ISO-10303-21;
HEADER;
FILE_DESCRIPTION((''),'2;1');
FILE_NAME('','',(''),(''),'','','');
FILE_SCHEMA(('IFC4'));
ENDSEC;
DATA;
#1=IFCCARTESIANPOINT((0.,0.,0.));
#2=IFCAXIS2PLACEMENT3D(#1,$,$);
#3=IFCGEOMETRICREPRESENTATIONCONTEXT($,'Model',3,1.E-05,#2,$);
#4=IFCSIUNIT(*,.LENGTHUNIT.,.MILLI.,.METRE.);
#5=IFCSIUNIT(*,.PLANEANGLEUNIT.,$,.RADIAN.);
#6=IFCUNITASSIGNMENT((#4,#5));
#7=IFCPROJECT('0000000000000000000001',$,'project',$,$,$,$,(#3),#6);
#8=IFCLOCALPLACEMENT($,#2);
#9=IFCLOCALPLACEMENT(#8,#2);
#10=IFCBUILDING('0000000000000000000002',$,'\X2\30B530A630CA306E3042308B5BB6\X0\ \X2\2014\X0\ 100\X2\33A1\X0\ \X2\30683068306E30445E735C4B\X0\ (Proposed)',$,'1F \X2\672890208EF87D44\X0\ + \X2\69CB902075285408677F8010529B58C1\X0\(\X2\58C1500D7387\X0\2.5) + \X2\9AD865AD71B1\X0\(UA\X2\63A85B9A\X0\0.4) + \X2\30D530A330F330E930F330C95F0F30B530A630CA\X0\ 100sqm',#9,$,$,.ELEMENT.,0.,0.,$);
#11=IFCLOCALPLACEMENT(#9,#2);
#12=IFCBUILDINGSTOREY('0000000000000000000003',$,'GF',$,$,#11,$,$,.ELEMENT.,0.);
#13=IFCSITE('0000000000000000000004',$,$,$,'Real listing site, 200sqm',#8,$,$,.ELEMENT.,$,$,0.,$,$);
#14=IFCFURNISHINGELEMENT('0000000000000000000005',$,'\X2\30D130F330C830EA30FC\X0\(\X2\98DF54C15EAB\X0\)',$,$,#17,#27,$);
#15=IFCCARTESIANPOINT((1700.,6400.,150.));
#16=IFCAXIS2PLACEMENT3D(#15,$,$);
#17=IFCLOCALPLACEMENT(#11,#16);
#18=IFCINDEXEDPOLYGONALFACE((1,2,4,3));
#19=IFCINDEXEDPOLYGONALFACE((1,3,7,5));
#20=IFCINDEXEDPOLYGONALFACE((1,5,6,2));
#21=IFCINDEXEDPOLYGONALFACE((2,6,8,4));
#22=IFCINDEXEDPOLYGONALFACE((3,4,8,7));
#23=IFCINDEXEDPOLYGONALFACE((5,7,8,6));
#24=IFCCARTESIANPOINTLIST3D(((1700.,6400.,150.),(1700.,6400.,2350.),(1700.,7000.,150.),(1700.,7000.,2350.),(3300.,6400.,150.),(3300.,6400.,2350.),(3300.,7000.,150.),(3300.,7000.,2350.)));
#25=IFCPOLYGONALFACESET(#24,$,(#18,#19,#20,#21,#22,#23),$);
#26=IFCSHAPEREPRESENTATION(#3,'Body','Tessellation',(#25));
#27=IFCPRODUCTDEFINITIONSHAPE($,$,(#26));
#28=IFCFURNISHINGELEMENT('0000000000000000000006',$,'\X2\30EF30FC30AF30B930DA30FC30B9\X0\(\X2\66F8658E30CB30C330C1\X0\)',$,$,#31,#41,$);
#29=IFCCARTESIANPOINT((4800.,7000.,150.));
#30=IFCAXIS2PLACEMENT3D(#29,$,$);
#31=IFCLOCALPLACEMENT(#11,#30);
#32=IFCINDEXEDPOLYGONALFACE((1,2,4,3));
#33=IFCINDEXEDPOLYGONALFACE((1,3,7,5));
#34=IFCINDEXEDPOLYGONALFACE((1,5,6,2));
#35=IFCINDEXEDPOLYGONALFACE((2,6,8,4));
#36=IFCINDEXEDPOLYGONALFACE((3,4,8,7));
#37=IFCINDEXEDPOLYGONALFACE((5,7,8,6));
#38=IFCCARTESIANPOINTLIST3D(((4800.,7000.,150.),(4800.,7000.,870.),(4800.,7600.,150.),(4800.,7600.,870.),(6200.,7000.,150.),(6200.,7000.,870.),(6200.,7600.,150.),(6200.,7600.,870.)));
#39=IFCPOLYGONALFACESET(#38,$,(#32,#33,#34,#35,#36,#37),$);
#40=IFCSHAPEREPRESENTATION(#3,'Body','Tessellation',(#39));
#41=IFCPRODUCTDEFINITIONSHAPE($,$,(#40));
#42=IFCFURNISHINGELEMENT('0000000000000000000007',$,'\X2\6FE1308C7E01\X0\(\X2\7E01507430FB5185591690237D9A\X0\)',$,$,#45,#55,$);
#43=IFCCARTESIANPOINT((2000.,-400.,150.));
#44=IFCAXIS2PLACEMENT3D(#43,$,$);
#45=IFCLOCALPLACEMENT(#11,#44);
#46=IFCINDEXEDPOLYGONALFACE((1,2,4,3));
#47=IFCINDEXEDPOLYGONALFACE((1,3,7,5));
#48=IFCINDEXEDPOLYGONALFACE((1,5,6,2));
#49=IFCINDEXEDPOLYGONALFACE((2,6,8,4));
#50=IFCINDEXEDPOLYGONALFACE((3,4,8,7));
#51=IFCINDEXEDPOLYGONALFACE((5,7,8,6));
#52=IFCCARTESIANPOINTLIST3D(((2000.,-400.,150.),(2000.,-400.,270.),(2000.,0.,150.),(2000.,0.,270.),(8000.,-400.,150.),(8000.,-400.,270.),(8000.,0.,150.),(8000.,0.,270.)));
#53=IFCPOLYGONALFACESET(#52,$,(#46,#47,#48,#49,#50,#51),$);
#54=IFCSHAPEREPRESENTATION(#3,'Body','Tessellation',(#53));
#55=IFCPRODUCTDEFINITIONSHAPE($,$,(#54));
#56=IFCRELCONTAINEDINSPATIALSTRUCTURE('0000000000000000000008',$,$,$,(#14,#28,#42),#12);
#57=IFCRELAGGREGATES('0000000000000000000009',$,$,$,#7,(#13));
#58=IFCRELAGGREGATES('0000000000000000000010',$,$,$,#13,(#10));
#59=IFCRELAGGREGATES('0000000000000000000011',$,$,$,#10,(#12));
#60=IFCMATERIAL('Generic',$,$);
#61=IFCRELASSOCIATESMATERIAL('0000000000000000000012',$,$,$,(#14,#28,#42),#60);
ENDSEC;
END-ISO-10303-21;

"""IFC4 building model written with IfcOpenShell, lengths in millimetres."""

from ifc_helpers import new_model, si_unit, frame, frame_2d, origin, place, context, project, spatial, rectangle, extrude, material, element, save


model = new_model("IFC4")

# Units and contexts
model_context = context("Model", 3, precision=1e-05, world=origin())
ifc_project = project(units=[si_unit("LENGTHUNIT", "METRE", prefix="MILLI"), si_unit("PLANEANGLEUNIT", "RADIAN")], contexts=[model_context])

# Site, building, storey
site_placement = place(None, origin())
site = spatial("IfcSite", under=ifc_project, at=site_placement, ObjectType="Real listing site, 200sqm", CompositionType="ELEMENT", RefElevation=0.0)
building_placement = place(site_placement, origin())
building = spatial("IfcBuilding", under=site, at=building_placement, Name="サウナのある家 — 100㎡ ととのい平屋 (Proposed)", ObjectType="1F 木造軸組 + 構造用合板耐力壁(壁倍率2.5) + 高断熱(UA推定0.4) + フィンランド式サウナ 100sqm", CompositionType="ELEMENT", ElevationOfRefHeight=0.0, ElevationOfTerrain=0.0)
storey_placement = place(building_placement, origin())
storey = spatial("IfcBuildingStorey", under=building, at=storey_placement, Name="GF", CompositionType="ELEMENT", Elevation=0.0)

# Shared definitions
ifc_material = material(Name="Generic")

# Furnishing elements
furnishing_1_placement = place(storey_placement, frame((1700.0, 6400.0, 150.0)))
element("IfcFurnishingElement", 1, at=furnishing_1_placement, inside=storey, material=ifc_material, Name="パントリー(食品庫)", context=model_context, shape_type="SweptSolid", body=[
    extrude(rectangle(XDim=1600.0, YDim=600.0, at=frame_2d((800.0, 300.0))), frame((1700.0, 6400.0, 150.0)), (0.0, 0.0, 1.0), 2200.0),
])
furnishing_2_placement = place(storey_placement, frame((4800.0, 7000.0, 150.0)))
element("IfcFurnishingElement", 2, at=furnishing_2_placement, inside=storey, material=ifc_material, Name="ワークスペース(書斎ニッチ)", context=model_context, shape_type="SweptSolid", body=[
    extrude(rectangle(XDim=1400.0, YDim=600.0, at=frame_2d((700.0, 300.0))), frame((4800.0, 7000.0, 150.0)), (0.0, 0.0, 1.0), 720.0),
])
furnishing_3_placement = place(storey_placement, frame((2000.0, -400.0, 150.0)))
element("IfcFurnishingElement", 3, at=furnishing_3_placement, inside=storey, material=ifc_material, Name="濡れ縁(縁側・内外連続)", context=model_context, shape_type="SweptSolid", body=[
    extrude(rectangle(XDim=6000.0, YDim=400.0, at=frame_2d((3000.0, 200.0))), frame((2000.0, -400.0, 150.0)), (0.0, 0.0, 1.0), 120.0),
])

save(model, "model.ifc")
